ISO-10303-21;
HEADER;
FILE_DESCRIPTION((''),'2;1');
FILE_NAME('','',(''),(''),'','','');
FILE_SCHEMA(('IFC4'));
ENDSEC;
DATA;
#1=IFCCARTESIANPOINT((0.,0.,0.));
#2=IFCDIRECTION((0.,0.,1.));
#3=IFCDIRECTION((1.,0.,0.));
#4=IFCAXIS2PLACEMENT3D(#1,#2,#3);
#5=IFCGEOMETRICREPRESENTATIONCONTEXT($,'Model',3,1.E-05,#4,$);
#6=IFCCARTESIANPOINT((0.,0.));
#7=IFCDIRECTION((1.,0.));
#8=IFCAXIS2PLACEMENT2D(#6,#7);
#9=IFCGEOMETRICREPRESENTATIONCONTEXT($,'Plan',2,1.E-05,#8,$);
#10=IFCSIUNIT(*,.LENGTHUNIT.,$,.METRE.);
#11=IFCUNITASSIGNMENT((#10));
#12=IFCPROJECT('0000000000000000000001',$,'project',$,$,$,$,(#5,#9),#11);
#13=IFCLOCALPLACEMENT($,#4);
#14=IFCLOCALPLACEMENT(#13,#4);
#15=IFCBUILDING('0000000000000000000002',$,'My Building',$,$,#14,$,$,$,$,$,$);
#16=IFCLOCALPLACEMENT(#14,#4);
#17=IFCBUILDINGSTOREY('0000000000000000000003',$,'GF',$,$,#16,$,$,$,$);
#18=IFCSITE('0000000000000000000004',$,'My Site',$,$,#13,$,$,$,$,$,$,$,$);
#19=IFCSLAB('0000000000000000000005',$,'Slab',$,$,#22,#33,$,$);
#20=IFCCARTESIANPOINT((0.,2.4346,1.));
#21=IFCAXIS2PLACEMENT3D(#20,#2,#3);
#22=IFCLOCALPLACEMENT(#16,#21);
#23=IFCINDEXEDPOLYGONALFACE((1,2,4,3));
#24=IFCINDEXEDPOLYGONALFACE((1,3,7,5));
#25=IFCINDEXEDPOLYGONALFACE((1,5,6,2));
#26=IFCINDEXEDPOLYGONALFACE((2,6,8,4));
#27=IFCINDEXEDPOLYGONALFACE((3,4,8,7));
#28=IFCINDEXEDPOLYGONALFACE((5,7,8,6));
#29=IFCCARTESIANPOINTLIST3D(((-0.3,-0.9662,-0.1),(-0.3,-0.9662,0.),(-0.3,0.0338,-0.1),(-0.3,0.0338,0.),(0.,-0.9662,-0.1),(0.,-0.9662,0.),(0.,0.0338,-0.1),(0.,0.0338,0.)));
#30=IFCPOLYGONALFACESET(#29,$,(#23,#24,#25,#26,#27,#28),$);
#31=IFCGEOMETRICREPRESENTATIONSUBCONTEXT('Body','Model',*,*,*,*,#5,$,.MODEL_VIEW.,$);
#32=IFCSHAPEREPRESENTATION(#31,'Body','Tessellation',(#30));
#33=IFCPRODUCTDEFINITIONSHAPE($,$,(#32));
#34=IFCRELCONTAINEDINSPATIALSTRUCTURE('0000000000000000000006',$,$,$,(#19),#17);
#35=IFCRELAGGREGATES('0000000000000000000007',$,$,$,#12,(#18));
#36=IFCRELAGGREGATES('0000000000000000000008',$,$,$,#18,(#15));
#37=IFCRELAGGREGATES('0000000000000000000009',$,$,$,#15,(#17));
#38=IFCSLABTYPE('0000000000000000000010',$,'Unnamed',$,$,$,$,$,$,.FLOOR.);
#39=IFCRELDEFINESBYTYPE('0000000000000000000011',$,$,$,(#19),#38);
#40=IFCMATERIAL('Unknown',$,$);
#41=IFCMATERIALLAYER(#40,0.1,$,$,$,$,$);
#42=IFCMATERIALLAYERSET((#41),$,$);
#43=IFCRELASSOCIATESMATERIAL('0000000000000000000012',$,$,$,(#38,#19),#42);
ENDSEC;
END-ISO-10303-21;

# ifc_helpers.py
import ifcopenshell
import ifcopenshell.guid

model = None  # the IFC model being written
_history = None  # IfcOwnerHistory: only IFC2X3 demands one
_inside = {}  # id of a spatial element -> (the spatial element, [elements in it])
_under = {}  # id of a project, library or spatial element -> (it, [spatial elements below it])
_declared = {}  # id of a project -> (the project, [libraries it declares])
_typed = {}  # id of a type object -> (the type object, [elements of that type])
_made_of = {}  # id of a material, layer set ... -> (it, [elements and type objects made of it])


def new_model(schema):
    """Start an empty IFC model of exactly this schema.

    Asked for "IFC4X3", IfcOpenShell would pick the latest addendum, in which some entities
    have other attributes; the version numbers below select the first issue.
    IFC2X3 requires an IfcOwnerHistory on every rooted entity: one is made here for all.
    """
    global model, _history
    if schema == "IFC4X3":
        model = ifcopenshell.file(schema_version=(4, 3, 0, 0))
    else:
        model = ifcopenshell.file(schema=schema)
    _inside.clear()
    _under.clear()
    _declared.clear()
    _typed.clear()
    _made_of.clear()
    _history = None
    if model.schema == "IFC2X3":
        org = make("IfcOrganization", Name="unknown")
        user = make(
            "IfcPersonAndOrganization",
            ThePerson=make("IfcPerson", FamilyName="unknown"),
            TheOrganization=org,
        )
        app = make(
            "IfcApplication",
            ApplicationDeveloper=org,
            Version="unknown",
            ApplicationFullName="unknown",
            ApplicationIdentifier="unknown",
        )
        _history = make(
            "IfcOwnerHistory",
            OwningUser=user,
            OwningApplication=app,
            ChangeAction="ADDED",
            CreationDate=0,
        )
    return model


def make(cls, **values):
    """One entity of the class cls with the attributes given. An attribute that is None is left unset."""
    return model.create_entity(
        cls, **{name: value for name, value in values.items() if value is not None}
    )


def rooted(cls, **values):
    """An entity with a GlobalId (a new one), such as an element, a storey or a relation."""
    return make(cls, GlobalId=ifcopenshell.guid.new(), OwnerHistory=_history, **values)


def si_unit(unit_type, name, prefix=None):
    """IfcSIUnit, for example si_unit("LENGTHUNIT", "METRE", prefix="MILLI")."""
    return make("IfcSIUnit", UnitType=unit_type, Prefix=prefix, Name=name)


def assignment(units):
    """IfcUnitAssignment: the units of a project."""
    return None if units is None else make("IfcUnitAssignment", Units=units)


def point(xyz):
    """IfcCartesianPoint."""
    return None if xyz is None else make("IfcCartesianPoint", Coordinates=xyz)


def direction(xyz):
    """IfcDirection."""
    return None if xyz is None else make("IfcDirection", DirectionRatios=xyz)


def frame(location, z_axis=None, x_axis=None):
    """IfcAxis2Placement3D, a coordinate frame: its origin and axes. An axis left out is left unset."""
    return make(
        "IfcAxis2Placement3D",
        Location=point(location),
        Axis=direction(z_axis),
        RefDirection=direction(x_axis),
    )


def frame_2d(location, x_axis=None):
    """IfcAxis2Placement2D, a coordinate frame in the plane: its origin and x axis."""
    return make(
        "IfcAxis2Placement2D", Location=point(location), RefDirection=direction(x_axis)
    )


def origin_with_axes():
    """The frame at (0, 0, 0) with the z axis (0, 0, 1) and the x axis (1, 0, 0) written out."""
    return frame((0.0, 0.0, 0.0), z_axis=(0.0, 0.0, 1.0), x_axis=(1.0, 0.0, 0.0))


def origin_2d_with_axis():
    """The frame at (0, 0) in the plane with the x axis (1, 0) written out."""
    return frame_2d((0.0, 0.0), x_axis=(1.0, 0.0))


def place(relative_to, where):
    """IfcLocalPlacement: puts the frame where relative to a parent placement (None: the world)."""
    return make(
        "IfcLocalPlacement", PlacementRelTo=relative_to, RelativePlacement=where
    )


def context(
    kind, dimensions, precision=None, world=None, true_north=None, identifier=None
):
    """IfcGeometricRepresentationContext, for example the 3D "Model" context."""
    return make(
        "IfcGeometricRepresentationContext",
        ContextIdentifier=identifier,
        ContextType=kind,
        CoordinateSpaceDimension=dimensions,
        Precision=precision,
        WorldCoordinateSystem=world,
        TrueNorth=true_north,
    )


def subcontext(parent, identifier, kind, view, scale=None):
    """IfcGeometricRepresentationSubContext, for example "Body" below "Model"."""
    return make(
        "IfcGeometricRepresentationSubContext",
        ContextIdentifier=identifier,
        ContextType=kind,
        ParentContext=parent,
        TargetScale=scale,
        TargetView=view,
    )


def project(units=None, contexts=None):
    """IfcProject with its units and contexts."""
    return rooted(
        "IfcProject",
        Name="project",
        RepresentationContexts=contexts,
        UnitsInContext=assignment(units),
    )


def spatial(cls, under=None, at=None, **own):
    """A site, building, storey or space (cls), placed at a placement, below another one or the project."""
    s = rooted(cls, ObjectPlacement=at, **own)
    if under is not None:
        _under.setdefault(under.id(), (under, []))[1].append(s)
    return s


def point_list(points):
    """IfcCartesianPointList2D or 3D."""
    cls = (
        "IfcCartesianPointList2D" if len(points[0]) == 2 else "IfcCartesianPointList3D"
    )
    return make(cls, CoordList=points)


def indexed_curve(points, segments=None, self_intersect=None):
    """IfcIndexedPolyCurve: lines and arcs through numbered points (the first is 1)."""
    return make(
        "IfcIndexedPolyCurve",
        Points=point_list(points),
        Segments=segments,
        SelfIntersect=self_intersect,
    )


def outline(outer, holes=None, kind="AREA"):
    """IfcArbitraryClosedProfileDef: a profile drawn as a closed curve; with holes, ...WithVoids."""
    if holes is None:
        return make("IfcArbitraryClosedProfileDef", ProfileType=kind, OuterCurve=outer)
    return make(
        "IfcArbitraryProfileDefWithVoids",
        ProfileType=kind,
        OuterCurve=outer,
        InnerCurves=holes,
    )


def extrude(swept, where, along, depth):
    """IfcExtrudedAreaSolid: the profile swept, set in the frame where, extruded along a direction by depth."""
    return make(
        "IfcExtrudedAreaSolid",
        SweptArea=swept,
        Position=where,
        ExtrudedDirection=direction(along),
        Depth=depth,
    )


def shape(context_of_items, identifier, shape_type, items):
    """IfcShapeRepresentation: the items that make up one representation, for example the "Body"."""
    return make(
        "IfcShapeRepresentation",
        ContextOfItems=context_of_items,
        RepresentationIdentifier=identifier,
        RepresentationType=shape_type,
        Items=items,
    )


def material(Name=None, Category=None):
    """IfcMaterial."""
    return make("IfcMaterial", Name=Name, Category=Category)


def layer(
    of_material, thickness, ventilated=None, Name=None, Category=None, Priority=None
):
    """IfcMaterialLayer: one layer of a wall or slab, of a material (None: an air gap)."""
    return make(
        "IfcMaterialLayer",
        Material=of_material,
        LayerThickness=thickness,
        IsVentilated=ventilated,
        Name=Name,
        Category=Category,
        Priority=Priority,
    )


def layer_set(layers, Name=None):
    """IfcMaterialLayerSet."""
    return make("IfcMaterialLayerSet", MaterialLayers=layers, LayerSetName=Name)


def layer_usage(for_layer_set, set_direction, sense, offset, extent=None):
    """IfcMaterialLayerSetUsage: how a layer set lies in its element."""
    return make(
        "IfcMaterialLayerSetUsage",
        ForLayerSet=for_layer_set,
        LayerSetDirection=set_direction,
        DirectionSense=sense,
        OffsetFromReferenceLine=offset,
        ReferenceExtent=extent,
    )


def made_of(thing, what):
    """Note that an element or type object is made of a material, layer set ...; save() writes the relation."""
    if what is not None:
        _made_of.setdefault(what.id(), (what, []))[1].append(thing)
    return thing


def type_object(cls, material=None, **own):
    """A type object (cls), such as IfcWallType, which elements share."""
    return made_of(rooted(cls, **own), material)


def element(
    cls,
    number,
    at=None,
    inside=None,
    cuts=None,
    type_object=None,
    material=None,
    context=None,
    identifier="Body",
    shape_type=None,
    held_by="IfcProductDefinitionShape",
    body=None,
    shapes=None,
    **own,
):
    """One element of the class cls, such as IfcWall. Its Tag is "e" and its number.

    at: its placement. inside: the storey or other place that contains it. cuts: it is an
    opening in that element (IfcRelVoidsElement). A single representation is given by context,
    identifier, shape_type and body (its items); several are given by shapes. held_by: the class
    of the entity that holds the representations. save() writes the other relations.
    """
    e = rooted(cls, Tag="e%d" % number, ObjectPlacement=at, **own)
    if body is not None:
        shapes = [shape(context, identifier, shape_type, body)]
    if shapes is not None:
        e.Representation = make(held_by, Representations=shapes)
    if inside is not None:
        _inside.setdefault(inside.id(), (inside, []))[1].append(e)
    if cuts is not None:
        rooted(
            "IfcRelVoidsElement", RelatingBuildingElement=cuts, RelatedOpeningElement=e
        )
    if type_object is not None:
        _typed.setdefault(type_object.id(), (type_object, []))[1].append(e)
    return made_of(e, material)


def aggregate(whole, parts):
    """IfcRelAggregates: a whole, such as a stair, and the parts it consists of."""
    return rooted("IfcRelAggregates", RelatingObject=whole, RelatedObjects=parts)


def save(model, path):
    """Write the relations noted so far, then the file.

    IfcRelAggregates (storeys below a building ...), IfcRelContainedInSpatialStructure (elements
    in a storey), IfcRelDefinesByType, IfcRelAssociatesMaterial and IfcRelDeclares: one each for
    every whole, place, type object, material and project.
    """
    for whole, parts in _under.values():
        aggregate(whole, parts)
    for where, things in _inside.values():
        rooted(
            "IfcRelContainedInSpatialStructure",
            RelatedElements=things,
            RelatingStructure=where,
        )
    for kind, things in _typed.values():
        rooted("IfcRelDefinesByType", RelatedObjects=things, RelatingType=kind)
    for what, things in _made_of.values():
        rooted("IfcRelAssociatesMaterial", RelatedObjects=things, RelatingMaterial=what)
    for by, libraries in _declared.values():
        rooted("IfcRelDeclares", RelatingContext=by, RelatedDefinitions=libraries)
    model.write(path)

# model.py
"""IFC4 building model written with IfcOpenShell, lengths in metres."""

from ifc_helpers import new_model, si_unit, frame, origin_with_axes, origin_2d_with_axis, place, context, subcontext, project, spatial, indexed_curve, outline, extrude, material, layer, layer_set, layer_usage, type_object, element, save


model = new_model("IFC4")

# Units and contexts
model_context = context("Model", 3, precision=1e-05, world=origin_with_axes())
plan_context = context("Plan", 2, precision=1e-05, world=origin_2d_with_axis())
body_context_1 = subcontext(model_context, "Body", "Model", "MODEL_VIEW")
ifc_project = project(units=[si_unit("LENGTHUNIT", "METRE")], contexts=[model_context, plan_context])

# Site, building, storey
site_placement = place(None, origin_with_axes())
site = spatial("IfcSite", under=ifc_project, at=site_placement, Name="My Site")
building_placement = place(site_placement, origin_with_axes())
building = spatial("IfcBuilding", under=site, at=building_placement, Name="My Building")
storey_placement = place(building_placement, origin_with_axes())
storey = spatial("IfcBuildingStorey", under=building, at=storey_placement, Name="GF")

# Shared definitions
ifc_material = material(Name="Unknown")

# Slab
ifc_layer_1 = layer(ifc_material, 0.1)
ifc_layer_set_1 = layer_set([ifc_layer_1])
slab_type = type_object("IfcSlabType", Name="Unnamed", PredefinedType="FLOOR", material=ifc_layer_set_1)
ifc_layer_usage_1 = layer_usage(ifc_layer_set_1, "AXIS3", "POSITIVE", -0.1)
slab_1_placement = place(storey_placement, frame((0.0, 2.4346, 1.0), z_axis=(0.0, 0.0, 1.0), x_axis=(1.0, 0.0, 0.0)))
element("IfcSlab", 1, at=slab_1_placement, inside=storey, type_object=slab_type, material=ifc_layer_usage_1, Name="Slab", context=body_context_1, shape_type="SweptSolid", body=[
    extrude(outline(indexed_curve([(-0.3, 0.0338), (-0.3, -0.9662), (0.0, -0.9662), (0.0, 0.0338), (-0.3, 0.0338)])), frame((0.0, 0.0, -0.1), z_axis=(0.0, 0.0, 1.0), x_axis=(1.0, 0.0, 0.0)), (0.0, 0.0, 1.0), 0.1),
])

save(model, "model.ifc")
